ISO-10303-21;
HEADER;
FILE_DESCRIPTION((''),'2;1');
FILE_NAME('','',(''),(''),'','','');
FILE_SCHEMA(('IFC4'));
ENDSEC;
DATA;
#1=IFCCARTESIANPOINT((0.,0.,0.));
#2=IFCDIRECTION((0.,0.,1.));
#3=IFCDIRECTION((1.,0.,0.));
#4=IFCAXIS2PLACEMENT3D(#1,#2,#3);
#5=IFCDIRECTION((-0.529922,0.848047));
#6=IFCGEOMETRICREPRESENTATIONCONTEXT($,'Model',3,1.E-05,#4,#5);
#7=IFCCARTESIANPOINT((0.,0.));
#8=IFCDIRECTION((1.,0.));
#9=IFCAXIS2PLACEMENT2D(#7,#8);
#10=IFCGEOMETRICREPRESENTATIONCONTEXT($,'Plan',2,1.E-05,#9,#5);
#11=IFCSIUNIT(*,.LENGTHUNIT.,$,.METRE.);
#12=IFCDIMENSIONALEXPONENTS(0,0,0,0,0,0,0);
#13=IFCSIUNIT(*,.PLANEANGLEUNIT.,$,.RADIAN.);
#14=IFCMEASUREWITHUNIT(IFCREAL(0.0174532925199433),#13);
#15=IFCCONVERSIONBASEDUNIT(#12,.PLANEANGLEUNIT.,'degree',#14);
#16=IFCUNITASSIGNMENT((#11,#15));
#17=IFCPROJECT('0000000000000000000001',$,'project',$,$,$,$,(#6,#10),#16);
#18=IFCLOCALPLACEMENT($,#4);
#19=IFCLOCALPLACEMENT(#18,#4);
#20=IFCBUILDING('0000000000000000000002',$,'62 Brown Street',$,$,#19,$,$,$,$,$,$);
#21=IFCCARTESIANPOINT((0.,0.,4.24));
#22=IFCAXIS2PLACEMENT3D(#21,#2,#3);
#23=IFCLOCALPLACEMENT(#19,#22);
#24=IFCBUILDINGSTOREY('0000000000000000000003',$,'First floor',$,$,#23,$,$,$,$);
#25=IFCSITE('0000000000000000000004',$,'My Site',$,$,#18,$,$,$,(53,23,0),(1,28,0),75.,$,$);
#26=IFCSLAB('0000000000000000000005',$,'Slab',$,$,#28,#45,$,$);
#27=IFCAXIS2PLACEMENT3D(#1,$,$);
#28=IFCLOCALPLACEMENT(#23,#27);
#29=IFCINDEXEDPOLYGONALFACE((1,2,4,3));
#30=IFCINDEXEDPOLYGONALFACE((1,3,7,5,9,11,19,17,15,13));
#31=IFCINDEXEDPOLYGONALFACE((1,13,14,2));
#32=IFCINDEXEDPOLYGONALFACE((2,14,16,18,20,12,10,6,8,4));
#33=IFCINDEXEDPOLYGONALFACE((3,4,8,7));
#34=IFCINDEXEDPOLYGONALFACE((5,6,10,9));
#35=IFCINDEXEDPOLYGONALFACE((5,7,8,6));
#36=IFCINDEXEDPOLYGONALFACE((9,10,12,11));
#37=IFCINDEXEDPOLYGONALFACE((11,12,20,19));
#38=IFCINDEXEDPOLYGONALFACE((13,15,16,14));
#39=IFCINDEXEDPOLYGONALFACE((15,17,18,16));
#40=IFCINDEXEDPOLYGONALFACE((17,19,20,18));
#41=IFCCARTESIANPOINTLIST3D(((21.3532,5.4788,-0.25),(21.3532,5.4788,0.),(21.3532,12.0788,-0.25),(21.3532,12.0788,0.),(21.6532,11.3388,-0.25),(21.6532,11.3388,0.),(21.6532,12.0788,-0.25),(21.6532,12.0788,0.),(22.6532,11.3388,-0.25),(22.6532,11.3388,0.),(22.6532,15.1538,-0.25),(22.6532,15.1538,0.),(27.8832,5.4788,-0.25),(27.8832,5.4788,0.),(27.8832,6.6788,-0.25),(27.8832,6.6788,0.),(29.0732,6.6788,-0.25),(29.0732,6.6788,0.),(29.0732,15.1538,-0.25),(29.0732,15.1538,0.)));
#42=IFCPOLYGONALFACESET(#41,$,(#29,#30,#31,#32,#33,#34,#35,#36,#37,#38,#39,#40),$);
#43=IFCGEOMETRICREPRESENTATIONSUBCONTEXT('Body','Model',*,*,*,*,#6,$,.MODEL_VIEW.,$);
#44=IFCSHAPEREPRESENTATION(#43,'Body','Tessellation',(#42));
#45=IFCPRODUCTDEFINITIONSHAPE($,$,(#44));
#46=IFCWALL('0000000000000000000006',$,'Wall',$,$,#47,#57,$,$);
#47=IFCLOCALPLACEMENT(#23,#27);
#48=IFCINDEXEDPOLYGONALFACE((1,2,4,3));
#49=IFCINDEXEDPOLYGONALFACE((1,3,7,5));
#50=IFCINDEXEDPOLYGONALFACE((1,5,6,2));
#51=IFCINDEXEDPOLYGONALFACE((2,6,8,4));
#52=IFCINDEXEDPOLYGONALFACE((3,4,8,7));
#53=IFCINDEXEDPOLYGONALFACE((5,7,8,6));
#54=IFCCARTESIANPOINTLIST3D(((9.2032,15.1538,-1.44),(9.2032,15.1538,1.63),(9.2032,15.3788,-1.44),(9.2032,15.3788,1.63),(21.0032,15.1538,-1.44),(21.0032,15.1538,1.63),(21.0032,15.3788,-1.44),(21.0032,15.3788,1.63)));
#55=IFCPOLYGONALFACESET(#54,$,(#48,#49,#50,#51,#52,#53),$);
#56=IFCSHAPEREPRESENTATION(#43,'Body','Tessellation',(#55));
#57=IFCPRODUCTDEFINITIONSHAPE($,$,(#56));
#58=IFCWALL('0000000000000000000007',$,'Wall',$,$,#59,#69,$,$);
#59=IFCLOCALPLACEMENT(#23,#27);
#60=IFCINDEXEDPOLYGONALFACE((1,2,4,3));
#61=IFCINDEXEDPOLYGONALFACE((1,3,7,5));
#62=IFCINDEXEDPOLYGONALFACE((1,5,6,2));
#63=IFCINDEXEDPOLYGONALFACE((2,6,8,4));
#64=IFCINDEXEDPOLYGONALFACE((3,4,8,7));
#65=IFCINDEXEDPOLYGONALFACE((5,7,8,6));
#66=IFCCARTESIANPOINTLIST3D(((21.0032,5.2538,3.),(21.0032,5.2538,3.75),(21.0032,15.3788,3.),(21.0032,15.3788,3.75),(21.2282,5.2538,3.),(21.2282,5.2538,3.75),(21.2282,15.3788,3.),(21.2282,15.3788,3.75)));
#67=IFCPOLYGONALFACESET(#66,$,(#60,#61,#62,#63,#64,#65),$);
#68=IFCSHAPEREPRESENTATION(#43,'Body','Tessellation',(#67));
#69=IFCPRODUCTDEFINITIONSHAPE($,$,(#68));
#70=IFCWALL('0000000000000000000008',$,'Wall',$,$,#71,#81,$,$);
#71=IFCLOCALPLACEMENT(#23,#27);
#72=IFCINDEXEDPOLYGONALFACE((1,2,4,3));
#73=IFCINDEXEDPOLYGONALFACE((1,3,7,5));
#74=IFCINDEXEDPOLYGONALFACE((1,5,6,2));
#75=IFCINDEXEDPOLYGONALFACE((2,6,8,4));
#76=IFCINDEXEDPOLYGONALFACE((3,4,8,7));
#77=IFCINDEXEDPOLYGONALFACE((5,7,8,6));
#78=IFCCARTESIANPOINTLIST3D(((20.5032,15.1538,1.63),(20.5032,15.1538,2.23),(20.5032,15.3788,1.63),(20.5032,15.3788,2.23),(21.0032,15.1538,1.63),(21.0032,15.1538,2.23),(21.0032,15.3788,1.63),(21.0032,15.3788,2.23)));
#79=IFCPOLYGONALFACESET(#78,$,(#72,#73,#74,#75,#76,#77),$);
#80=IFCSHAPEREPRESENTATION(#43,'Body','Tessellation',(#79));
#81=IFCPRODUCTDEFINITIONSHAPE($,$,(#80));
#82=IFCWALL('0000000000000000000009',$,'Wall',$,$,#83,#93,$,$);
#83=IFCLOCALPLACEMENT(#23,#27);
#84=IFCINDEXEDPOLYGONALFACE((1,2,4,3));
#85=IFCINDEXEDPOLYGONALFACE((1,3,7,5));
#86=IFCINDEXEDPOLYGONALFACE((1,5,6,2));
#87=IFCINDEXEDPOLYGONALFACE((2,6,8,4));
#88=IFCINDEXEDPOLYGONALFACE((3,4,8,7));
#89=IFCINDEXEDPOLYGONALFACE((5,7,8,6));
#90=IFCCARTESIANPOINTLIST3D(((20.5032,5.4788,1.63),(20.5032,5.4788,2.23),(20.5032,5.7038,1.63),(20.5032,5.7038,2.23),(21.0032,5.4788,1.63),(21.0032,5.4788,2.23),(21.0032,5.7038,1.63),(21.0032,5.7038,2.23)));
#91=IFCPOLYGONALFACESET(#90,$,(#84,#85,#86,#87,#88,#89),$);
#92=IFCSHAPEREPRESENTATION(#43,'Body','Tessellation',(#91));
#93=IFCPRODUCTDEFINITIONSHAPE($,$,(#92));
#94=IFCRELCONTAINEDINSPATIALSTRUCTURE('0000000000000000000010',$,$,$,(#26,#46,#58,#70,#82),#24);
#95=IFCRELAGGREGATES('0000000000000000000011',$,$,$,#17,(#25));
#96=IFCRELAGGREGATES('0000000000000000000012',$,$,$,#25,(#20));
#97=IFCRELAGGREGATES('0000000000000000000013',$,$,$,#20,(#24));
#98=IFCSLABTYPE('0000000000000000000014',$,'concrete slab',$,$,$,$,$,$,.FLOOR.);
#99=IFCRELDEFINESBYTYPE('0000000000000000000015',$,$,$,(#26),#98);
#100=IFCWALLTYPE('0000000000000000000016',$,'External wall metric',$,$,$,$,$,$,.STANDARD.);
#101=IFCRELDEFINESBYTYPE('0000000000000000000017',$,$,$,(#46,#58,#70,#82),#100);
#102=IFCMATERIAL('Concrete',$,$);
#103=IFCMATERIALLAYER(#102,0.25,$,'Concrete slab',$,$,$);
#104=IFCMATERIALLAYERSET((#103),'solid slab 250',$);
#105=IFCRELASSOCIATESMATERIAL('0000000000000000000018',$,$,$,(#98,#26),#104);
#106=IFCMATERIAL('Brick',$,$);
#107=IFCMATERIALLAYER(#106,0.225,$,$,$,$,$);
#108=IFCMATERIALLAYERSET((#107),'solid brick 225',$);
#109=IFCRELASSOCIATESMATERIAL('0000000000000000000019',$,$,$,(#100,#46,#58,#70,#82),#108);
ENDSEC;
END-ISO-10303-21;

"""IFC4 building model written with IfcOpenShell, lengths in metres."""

from ifc_helpers import new_model, entity, si_unit, converted_unit, direction, frame, origin_with_axes, origin_2d_with_axis, place, context, subcontext, project, spatial, indexed_curve, outline, extrude, material, layer, layer_set, layer_usage, type_object, element, save


model = new_model("IFC4")

# Units and contexts
model_context = context("Model", 3, precision=1e-05, world=origin_with_axes(), true_north=direction((-0.529922, 0.848047)))
plan_context = context("Plan", 2, precision=1e-05, world=origin_2d_with_axis(), true_north=direction((-0.529922, 0.848047)))
body_context = subcontext(model_context, "Body", "Model", "MODEL_VIEW")
ifc_project = project(units=[si_unit("LENGTHUNIT", "METRE"), converted_unit("PLANEANGLEUNIT", "degree", entity("IfcReal", 0.0174532925199433), si_unit("PLANEANGLEUNIT", "RADIAN"), dimensions=[0, 0, 0, 0, 0, 0, 0])], contexts=[model_context, plan_context])

# Site, building, storey
site_placement = place(None, origin_with_axes())
site = spatial("IfcSite", under=ifc_project, at=site_placement, Name="My Site", RefLatitude=(53, 23, 0), RefLongitude=(1, 28, 0), RefElevation=75.0)
building_placement = place(site_placement, origin_with_axes())
building = spatial("IfcBuilding", under=site, at=building_placement, Name="62 Brown Street")
storey_placement = place(building_placement, frame((0.0, 0.0, 4.24), z_axis=(0.0, 0.0, 1.0), x_axis=(1.0, 0.0, 0.0)))
storey = spatial("IfcBuildingStorey", under=building, at=storey_placement, Name="First floor")

# Shared definitions
ifc_material_1 = material(Name="Concrete")

# Slab
ifc_layer_1 = layer(ifc_material_1, 0.25, Name="Concrete slab")
ifc_layer_set_1 = layer_set([ifc_layer_1], Name="solid slab 250")
ifc_layer_usage_1 = layer_usage(ifc_layer_set_1, "AXIS3", "POSITIVE", 0.0)
slab_type = type_object("IfcSlabType", Name="concrete slab", PredefinedType="FLOOR", material=ifc_layer_set_1)
slab_placement = place(storey_placement, frame((21.3532, 5.4788, -0.25), z_axis=(0.0, 0.0, 1.0), x_axis=(1.0, 0.0, 0.0)))
element("IfcSlab", 1, at=slab_placement, inside=storey, type_object=slab_type, material=ifc_layer_usage_1, Name="Slab", context=body_context, shape_type="SweptSolid", body=[
    extrude(outline(indexed_curve([(6.53, 1.2), (6.53, 0.0), (0.0, 0.0), (0.0, 6.6), (0.3, 6.6), (0.3, 5.86), (1.3, 5.86), (1.3, 9.675), (7.72, 9.675), (7.72, 1.2), (6.53, 1.2)])), None, (0.0, 0.0, 1.0), 0.25),
])

# Walls
ifc_material_2 = material(Name="Brick")
ifc_layer_2 = layer(ifc_material_2, 0.225)
ifc_layer_set_2 = layer_set([ifc_layer_2], Name="solid brick 225")
ifc_layer_usage_2 = layer_usage(ifc_layer_set_2, "AXIS2", "POSITIVE", 0.0)
wall_type_1 = type_object("IfcWallType", Name="External wall metric", PredefinedType="STANDARD", material=ifc_layer_set_2)
wall_1_placement = place(storey_placement, frame((21.0032, 15.3788, -1.44), z_axis=(0.0, 0.0, 1.0), x_axis=(-1.0, 0.0, 0.0)))
element("IfcWall", 2, at=wall_1_placement, inside=storey, type_object=wall_type_1, material=ifc_layer_usage_2, Name="Wall", context=body_context, shape_type="SweptSolid", body=[
    extrude(outline(indexed_curve([(0.0, 0.0), (0.0, 0.225), (11.8, 0.225), (11.8, 0.0), (0.0, 0.0)], self_intersect=False)), origin_with_axes(), (0.0, 0.0, 1.0), 3.07),
])
ifc_layer_usage_3 = layer_usage(ifc_layer_set_2, "AXIS2", "POSITIVE", 0.0)
wall_2_placement = place(storey_placement, frame((21.0032, 15.3788, 3.0), z_axis=(0.0, 0.0, 1.0), x_axis=(0.0, -1.0, 0.0)))
element("IfcWall", 3, at=wall_2_placement, inside=storey, type_object=wall_type_1, material=ifc_layer_usage_3, Name="Wall", context=body_context, shape_type="SweptSolid", body=[
    extrude(outline(indexed_curve([(0.0, 0.0), (0.0, 0.225), (10.125, 0.225), (10.125, 0.0), (0.0, 0.0)], self_intersect=False)), origin_with_axes(), (0.0, 0.0, 1.0), 0.75),
])
ifc_layer_usage_4 = layer_usage(ifc_layer_set_2, "AXIS2", "POSITIVE", 0.0)
wall_3_placement = place(storey_placement, frame((21.0032, 15.3788, 1.63), z_axis=(0.0, 0.0, 1.0), x_axis=(-1.0, 0.0, 0.0)))
element("IfcWall", 4, at=wall_3_placement, inside=storey, type_object=wall_type_1, material=ifc_layer_usage_4, Name="Wall", context=body_context, shape_type="SweptSolid", body=[
    extrude(outline(indexed_curve([(0.0, 0.0), (0.0, 0.225), (0.5, 0.225), (0.5, 0.0), (0.0, 0.0)], self_intersect=False)), origin_with_axes(), (0.0, 0.0, 1.0), 0.6),
])
ifc_layer_usage_5 = layer_usage(ifc_layer_set_2, "AXIS2", "POSITIVE", 0.0)
wall_4_placement = place(storey_placement, frame((20.5032, 5.4788, 1.63), z_axis=(0.0, 0.0, 1.0), x_axis=(1.0, 0.0, 0.0)))
element("IfcWall", 5, at=wall_4_placement, inside=storey, type_object=wall_type_1, material=ifc_layer_usage_5, Name="Wall", context=body_context, shape_type="SweptSolid", body=[
    extrude(outline(indexed_curve([(0.0, 0.0), (0.0, 0.225), (0.5, 0.225), (0.5, 0.0), (0.0, 0.0)], self_intersect=False)), origin_with_axes(), (0.0, 0.0, 1.0), 0.6),
])

save(model, "model.ifc")
